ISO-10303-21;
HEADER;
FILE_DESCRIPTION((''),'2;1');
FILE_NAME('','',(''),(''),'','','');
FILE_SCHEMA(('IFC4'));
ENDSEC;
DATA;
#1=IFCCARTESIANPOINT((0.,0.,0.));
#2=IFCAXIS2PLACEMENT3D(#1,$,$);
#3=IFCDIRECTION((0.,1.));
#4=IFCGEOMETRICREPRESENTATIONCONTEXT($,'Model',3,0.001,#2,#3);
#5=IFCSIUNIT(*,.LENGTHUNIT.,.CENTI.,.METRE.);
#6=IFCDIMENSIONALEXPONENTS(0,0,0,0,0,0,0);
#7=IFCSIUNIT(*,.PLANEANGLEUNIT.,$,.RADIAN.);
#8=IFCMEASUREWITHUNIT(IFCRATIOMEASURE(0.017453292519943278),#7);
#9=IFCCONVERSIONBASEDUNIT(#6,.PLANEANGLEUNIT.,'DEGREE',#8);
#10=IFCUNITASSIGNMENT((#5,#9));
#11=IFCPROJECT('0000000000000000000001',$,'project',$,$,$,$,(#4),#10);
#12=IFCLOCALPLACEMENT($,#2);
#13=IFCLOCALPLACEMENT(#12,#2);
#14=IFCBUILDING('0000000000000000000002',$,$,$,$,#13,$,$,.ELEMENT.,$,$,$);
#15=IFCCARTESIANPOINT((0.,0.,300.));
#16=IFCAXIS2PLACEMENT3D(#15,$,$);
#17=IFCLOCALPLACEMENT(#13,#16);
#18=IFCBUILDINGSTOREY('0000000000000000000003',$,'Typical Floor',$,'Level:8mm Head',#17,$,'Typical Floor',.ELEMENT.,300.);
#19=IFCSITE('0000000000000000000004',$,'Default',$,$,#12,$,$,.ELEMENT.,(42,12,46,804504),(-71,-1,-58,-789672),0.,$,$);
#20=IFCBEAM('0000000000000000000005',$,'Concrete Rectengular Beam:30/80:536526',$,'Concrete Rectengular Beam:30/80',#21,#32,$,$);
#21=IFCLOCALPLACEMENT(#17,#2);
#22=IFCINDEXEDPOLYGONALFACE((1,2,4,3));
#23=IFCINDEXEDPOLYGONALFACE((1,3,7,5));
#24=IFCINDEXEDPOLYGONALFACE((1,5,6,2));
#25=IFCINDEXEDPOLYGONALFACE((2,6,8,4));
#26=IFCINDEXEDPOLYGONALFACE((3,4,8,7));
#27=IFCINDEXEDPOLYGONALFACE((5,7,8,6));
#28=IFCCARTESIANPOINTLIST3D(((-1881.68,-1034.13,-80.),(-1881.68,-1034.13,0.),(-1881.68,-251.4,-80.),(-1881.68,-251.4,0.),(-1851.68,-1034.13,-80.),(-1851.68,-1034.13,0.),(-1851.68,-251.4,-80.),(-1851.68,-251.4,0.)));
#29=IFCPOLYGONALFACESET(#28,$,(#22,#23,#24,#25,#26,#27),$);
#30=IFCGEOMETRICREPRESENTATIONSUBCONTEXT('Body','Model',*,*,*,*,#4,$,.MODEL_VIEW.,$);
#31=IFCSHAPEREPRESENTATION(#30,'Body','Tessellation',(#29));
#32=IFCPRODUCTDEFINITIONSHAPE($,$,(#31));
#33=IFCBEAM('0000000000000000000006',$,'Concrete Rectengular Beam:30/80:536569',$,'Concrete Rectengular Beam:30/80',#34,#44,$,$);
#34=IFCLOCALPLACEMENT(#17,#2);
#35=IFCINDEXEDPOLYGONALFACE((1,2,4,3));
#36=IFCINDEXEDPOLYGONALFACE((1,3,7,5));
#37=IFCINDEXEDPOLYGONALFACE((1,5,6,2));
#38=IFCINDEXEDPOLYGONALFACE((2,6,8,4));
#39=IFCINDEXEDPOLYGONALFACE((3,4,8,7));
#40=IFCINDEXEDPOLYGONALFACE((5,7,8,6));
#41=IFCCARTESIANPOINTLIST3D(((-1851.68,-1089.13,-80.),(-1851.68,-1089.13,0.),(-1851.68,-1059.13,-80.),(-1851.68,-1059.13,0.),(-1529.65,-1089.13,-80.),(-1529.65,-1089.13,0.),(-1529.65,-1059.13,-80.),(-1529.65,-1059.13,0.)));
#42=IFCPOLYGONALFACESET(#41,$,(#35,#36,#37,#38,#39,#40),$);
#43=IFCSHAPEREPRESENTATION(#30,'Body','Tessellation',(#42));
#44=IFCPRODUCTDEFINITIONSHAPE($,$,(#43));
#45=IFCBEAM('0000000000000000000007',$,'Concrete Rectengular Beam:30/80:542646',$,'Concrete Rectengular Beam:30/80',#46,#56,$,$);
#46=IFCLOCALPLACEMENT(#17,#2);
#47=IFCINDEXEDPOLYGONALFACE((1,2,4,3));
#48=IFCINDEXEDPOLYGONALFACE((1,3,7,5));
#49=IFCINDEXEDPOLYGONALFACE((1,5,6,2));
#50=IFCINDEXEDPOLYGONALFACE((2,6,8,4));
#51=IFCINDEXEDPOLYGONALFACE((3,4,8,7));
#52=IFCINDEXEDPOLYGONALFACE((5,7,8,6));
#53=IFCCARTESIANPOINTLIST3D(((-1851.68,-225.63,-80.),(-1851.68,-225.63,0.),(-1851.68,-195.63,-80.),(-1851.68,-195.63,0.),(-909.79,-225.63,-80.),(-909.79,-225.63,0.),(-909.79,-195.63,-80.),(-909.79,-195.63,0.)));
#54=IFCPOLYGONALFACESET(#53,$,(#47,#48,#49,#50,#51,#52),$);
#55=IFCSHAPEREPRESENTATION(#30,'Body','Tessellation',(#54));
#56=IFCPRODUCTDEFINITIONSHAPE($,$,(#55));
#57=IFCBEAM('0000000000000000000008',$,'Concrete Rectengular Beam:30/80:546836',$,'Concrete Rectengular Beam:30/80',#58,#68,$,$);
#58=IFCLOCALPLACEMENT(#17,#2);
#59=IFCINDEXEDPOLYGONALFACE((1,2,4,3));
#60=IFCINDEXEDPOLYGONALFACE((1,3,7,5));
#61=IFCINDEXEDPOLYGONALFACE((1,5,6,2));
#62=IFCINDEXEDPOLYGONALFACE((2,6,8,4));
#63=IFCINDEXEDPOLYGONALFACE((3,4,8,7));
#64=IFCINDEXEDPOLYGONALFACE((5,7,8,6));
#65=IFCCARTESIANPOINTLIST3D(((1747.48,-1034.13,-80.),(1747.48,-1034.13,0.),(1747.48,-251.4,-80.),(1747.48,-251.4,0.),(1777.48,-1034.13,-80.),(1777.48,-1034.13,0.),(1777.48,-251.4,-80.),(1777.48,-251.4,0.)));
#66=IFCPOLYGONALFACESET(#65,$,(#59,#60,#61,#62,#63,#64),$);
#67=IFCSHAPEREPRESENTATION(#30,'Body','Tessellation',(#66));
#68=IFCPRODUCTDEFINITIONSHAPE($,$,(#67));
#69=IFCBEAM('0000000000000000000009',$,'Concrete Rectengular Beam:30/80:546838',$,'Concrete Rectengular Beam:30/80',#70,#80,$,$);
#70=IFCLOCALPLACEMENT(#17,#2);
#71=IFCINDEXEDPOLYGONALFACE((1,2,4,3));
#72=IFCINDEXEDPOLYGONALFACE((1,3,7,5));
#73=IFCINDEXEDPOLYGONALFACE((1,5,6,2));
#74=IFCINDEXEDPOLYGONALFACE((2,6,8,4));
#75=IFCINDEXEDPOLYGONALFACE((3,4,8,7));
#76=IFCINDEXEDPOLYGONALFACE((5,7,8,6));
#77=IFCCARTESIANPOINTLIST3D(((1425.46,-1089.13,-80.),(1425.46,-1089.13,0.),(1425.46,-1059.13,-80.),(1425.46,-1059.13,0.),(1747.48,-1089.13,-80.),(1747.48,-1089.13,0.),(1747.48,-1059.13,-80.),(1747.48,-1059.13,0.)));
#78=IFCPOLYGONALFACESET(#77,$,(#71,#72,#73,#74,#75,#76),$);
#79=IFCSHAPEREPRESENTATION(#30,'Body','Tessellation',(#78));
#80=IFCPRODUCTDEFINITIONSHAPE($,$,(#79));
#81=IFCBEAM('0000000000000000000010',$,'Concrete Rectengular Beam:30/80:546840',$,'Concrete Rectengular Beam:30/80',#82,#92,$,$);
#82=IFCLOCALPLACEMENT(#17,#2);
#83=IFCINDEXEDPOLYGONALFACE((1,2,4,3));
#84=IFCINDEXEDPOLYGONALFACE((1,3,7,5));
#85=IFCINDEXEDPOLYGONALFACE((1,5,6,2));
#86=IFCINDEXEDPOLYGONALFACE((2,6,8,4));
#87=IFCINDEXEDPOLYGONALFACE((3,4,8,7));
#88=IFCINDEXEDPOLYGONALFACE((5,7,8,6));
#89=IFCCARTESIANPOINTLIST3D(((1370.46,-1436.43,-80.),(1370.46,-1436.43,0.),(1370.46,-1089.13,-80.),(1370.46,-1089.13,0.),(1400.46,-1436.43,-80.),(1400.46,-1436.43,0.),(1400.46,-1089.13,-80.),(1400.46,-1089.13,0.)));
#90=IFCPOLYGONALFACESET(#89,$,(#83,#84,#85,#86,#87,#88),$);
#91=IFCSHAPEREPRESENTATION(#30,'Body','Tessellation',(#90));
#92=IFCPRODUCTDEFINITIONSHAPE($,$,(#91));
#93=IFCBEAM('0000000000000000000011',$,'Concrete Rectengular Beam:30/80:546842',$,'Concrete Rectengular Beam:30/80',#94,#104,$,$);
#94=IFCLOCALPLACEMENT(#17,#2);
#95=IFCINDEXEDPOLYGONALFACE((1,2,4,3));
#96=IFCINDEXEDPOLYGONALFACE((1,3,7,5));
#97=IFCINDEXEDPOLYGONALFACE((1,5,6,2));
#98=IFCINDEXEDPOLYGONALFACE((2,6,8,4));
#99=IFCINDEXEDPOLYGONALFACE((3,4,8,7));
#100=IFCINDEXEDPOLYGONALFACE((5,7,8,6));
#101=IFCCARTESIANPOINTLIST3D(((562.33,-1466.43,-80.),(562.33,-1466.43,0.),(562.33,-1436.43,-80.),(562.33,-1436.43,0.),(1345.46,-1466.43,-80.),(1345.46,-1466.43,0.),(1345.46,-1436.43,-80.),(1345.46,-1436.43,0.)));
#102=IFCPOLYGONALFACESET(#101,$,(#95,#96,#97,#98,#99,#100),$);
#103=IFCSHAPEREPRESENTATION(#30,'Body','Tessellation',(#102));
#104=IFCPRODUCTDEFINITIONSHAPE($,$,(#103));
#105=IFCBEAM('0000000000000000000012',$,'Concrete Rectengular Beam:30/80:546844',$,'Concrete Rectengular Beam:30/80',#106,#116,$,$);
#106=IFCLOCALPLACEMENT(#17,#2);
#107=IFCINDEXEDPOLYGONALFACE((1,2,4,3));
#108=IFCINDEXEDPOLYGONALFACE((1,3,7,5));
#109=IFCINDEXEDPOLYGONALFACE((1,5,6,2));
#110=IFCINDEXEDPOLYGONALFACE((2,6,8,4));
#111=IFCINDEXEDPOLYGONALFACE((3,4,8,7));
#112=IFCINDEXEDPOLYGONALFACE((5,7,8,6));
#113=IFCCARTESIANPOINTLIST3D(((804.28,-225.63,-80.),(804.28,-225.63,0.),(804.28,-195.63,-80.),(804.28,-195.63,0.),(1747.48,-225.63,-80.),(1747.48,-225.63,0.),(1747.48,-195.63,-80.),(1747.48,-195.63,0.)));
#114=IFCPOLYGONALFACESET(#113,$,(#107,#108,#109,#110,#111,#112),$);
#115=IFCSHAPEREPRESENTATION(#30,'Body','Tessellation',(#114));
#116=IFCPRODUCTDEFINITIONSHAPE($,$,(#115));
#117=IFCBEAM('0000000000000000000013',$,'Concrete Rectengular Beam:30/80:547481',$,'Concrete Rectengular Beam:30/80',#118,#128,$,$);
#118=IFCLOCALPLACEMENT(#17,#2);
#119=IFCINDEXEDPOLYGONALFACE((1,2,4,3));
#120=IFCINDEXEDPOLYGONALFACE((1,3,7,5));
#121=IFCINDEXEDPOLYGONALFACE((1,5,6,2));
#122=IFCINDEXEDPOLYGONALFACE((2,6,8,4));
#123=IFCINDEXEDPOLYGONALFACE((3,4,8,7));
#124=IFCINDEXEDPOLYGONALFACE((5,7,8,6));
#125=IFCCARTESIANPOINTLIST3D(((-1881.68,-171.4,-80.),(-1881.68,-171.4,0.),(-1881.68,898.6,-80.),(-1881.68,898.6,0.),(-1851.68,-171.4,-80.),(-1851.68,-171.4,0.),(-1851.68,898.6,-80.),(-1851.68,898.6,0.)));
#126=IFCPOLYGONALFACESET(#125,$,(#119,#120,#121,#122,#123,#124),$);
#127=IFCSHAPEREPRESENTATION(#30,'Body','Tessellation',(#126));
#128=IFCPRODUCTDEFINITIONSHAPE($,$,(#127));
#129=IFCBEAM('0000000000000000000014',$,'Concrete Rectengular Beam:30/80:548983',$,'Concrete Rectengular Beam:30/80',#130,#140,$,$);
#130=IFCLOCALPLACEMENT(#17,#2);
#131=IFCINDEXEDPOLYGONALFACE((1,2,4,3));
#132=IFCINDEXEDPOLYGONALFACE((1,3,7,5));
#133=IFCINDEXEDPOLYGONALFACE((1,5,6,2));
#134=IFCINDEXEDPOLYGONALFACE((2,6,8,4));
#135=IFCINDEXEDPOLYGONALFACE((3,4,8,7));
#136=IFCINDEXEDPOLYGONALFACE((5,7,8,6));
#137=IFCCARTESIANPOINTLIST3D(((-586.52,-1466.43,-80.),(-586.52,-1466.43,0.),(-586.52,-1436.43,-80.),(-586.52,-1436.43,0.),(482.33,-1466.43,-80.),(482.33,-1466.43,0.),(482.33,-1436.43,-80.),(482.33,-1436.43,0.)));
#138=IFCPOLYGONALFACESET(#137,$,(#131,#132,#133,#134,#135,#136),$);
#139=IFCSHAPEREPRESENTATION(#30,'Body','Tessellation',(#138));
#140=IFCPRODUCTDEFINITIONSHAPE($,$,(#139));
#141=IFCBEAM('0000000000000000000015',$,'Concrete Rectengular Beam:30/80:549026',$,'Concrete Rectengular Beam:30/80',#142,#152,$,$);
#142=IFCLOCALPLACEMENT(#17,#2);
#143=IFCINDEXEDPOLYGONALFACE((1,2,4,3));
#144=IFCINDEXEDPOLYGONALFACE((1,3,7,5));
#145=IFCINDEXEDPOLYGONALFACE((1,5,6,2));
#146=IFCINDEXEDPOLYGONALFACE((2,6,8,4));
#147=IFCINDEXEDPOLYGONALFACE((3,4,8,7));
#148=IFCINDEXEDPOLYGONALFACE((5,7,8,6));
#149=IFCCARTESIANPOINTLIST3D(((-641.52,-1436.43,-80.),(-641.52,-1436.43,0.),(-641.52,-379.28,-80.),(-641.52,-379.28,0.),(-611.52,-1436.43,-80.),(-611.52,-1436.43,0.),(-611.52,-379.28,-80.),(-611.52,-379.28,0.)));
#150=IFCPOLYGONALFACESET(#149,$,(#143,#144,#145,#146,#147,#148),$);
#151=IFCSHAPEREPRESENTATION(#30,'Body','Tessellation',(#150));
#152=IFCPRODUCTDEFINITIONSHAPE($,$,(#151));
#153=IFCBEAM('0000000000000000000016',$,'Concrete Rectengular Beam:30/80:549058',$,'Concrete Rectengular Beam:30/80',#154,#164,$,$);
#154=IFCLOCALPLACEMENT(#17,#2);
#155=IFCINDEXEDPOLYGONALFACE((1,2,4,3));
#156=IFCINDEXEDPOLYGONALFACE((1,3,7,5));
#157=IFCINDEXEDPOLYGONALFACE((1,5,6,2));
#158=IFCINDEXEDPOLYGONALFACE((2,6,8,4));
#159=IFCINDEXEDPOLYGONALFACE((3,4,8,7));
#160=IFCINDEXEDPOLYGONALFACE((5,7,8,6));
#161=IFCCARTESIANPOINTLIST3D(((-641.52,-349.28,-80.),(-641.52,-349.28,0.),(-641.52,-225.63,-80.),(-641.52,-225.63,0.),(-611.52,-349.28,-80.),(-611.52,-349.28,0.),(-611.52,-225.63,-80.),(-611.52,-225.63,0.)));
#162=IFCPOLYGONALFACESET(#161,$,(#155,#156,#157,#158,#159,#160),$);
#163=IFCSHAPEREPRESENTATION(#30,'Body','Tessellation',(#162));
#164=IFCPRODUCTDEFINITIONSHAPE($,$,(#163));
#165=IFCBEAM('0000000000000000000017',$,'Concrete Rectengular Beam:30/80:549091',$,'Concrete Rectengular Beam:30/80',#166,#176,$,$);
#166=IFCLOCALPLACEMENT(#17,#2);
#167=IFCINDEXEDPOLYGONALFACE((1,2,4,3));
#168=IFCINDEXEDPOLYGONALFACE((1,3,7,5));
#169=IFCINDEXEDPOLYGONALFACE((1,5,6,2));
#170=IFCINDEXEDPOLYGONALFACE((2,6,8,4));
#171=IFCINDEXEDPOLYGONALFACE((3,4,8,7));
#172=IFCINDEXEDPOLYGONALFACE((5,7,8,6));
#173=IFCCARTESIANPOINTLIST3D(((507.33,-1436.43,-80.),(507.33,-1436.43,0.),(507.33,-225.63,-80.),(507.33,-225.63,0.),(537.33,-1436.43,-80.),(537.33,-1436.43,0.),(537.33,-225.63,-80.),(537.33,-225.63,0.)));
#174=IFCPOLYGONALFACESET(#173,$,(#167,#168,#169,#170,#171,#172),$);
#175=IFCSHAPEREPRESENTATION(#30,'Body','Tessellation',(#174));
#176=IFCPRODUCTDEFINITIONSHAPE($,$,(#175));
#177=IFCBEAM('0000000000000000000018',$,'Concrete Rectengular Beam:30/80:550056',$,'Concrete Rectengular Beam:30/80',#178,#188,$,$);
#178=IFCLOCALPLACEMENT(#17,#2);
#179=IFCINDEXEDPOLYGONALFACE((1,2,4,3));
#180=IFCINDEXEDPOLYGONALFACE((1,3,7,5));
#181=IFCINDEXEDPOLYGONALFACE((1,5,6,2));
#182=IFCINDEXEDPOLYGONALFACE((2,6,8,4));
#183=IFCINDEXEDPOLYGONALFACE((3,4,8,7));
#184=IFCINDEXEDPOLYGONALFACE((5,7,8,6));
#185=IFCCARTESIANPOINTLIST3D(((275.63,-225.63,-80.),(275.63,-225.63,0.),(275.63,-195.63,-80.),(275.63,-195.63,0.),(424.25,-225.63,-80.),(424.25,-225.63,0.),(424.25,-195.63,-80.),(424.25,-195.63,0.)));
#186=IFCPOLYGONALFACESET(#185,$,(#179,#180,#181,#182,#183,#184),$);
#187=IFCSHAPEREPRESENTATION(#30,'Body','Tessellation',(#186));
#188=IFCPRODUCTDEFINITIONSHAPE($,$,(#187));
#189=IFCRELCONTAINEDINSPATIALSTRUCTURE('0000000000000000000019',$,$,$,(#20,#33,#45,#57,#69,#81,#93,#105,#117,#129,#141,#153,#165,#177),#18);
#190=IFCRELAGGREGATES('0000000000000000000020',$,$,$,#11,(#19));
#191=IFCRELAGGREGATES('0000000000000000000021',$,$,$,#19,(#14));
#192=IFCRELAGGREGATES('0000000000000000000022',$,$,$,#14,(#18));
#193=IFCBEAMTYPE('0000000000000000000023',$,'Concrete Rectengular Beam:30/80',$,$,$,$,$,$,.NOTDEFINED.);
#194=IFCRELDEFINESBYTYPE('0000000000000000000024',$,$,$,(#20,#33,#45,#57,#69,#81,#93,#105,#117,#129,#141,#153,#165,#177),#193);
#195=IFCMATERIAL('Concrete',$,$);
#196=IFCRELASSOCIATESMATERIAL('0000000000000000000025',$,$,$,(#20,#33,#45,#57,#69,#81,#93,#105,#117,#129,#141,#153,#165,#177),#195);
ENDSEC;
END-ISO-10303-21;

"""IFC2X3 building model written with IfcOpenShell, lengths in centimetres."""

from ifc_helpers import new_model, entity, si_unit, converted_unit, direction, frame, frame_2d, origin, origin_2d_with_axis, place, context, subcontext, project, spatial, rectangle, extrude, material, type_object, element, save


model = new_model("IFC2X3")

# Units and contexts
model_context = context("Model", 3, precision=0.001, world=origin(), true_north=direction((0.0, 1.0)))
body_context = subcontext(model_context, "Body", "Model", "MODEL_VIEW")
ifc_project = project(units=[si_unit("LENGTHUNIT", "METRE", prefix="CENTI"), converted_unit("PLANEANGLEUNIT", "DEGREE", entity("IfcRatioMeasure", 0.017453292519943278), si_unit("PLANEANGLEUNIT", "RADIAN"), dimensions=[0, 0, 0, 0, 0, 0, 0])], contexts=[model_context])

# Site, building, storey
site_placement = place(None, origin())
site = spatial("IfcSite", under=ifc_project, at=site_placement, Name="Default", CompositionType="ELEMENT", RefLatitude=(42, 12, 46, 804504), RefLongitude=(-71, -1, -58, -789672), RefElevation=0.0)
building_placement = place(site_placement, origin())
building = spatial("IfcBuilding", under=site, at=building_placement, CompositionType="ELEMENT")
storey_placement = place(building_placement, frame((0.0, 0.0, 300.0)))
storey = spatial("IfcBuildingStorey", under=building, at=storey_placement, Name="Typical Floor", ObjectType="Level:8mm Head", LongName="Typical Floor", CompositionType="ELEMENT", Elevation=300.0)

# Beams
ifc_material = material(Name="Concrete")
beam_type = type_object("IfcBeamType", Name="Concrete Rectengular Beam:30/80", PredefinedType="NOTDEFINED")
beam_1_placement = place(storey_placement, frame((-1866.68, -1074.13, 0.0), z_axis=(0.0, 0.0, 1.0), x_axis=(0.0, 1.0, 0.0)))
element("IfcBeam", 1, at=beam_1_placement, inside=storey, type_object=beam_type, material=ifc_material, Name="Concrete Rectengular Beam:30/80:536526", ObjectType="Concrete Rectengular Beam:30/80", context=body_context, shape_type="SweptSolid", body=[
    extrude(rectangle(XDim=80.0, YDim=30.0, at=frame_2d((0.0, 0.0), x_axis=(1.0, 0.0))), frame((40.0, 0.0, -40.0), z_axis=(1.0, 0.0, 0.0), x_axis=(0.0, 0.0, -1.0)), (0.0, 0.0, 1.0), 782.73),
])
beam_2_placement = place(storey_placement, frame((-1866.68, -1074.13, 0.0)))
element("IfcBeam", 2, at=beam_2_placement, inside=storey, type_object=beam_type, material=ifc_material, Name="Concrete Rectengular Beam:30/80:536569", ObjectType="Concrete Rectengular Beam:30/80", context=body_context, shape_type="SweptSolid", body=[
    extrude(rectangle(XDim=80.0, YDim=30.0, at=frame_2d((0.0, 0.0), x_axis=(1.0, 0.0))), frame((15.0, 0.0, -40.0), z_axis=(1.0, 0.0, 0.0), x_axis=(0.0, 0.0, -1.0)), (0.0, 0.0, 1.0), 322.02),
])
beam_3_placement = place(storey_placement, frame((-894.79, -210.63, 0.0), z_axis=(0.0, 0.0, 1.0), x_axis=(-1.0, 0.0, 0.0)))
element("IfcBeam", 3, at=beam_3_placement, inside=storey, type_object=beam_type, material=ifc_material, Name="Concrete Rectengular Beam:30/80:542646", ObjectType="Concrete Rectengular Beam:30/80", context=body_context, shape_type="SweptSolid", body=[
    extrude(rectangle(XDim=80.0, YDim=30.0, at=frame_2d((0.0, 0.0), x_axis=(1.0, 0.0))), frame((15.0, 0.0, -40.0), z_axis=(1.0, 0.0, 0.0), x_axis=(0.0, 0.0, -1.0)), (0.0, 0.0, 1.0), 941.89),
])
beam_4_placement = place(storey_placement, frame((1762.48, -1074.13, 0.0), z_axis=(0.0, 0.0, 1.0), x_axis=(0.0, 1.0, 0.0)))
element("IfcBeam", 4, at=beam_4_placement, inside=storey, type_object=beam_type, material=ifc_material, Name="Concrete Rectengular Beam:30/80:546836", ObjectType="Concrete Rectengular Beam:30/80", context=body_context, shape_type="SweptSolid", body=[
    extrude(rectangle(XDim=80.0, YDim=30.0, at=frame_2d((0.0, 0.0), x_axis=(1.0, 0.0))), frame((40.0, 0.0, -40.0), z_axis=(1.0, 0.0, 0.0), x_axis=(0.0, 0.0, -1.0)), (0.0, 0.0, 1.0), 782.73),
])
beam_5_placement = place(storey_placement, frame((1762.48, -1074.13, 0.0), z_axis=(0.0, 0.0, 1.0), x_axis=(-1.0, 0.0, 0.0)))
element("IfcBeam", 5, at=beam_5_placement, inside=storey, type_object=beam_type, material=ifc_material, Name="Concrete Rectengular Beam:30/80:546838", ObjectType="Concrete Rectengular Beam:30/80", context=body_context, shape_type="SweptSolid", body=[
    extrude(rectangle(XDim=80.0, YDim=30.0, at=frame_2d((0.0, 0.0), x_axis=(1.0, 0.0))), frame((15.0, 0.0, -40.0), z_axis=(1.0, 0.0, 0.0), x_axis=(0.0, 0.0, -1.0)), (0.0, 0.0, 1.0), 322.02),
])
beam_6_placement = place(storey_placement, frame((1385.46, -1451.43, 0.0), z_axis=(0.0, 0.0, 1.0), x_axis=(0.0, 1.0, 0.0)))
element("IfcBeam", 6, at=beam_6_placement, inside=storey, type_object=beam_type, material=ifc_material, Name="Concrete Rectengular Beam:30/80:546840", ObjectType="Concrete Rectengular Beam:30/80", context=body_context, shape_type="SweptSolid", body=[
    extrude(rectangle(XDim=80.0, YDim=30.0, at=frame_2d((0.0, 0.0), x_axis=(1.0, 0.0))), frame((15.0, 0.0, -40.0), z_axis=(1.0, 0.0, 0.0), x_axis=(0.0, 0.0, -1.0)), (0.0, 0.0, 1.0), 347.31),
])
beam_7_placement = place(storey_placement, frame((1385.46, -1451.43, 0.0), z_axis=(0.0, 0.0, 1.0), x_axis=(-1.0, 0.0, 0.0)))
element("IfcBeam", 7, at=beam_7_placement, inside=storey, type_object=beam_type, material=ifc_material, Name="Concrete Rectengular Beam:30/80:546842", ObjectType="Concrete Rectengular Beam:30/80", context=body_context, shape_type="SweptSolid", body=[
    extrude(rectangle(XDim=80.0, YDim=30.0, at=frame_2d((0.0, 0.0), x_axis=(1.0, 0.0))), frame((40.0, 0.0, -40.0), z_axis=(1.0, 0.0, 0.0), x_axis=(0.0, 0.0, -1.0)), (0.0, 0.0, 1.0), 783.13),
])
beam_8_placement = place(storey_placement, frame((789.28, -210.63, 0.0)))
element("IfcBeam", 8, at=beam_8_placement, inside=storey, type_object=beam_type, material=ifc_material, Name="Concrete Rectengular Beam:30/80:546844", ObjectType="Concrete Rectengular Beam:30/80", context=body_context, shape_type="SweptSolid", body=[
    extrude(rectangle(XDim=80.0, YDim=30.0, at=frame_2d((0.0, 0.0), x_axis=(1.0, 0.0))), frame((15.0, 0.0, -40.0), z_axis=(1.0, 0.0, 0.0), x_axis=(0.0, 0.0, -1.0)), (0.0, 0.0, 1.0), 943.2),
])
beam_9_placement = place(storey_placement, frame((-1866.68, -211.4, 0.0), z_axis=(0.0, 0.0, 1.0), x_axis=(0.0, 1.0, 0.0)))
element("IfcBeam", 9, at=beam_9_placement, inside=storey, type_object=beam_type, material=ifc_material, Name="Concrete Rectengular Beam:30/80:547481", ObjectType="Concrete Rectengular Beam:30/80", context=body_context, shape_type="SweptSolid", body=[
    extrude(rectangle(XDim=80.0, YDim=30.0, at=frame_2d((0.0, 0.0), x_axis=(1.0, 0.0))), frame((40.0, 0.0, -40.0), z_axis=(1.0, 0.0, 0.0), x_axis=(0.0, 0.0, -1.0)), (0.0, 0.0, 1.0), 1070.0),
])
beam_10_placement = place(storey_placement, frame((522.33, -1451.43, 0.0), z_axis=(0.0, 0.0, 1.0), x_axis=(-1.0, 0.0, 0.0)))
element("IfcBeam", 10, at=beam_10_placement, inside=storey, type_object=beam_type, material=ifc_material, Name="Concrete Rectengular Beam:30/80:548983", ObjectType="Concrete Rectengular Beam:30/80", context=body_context, shape_type="SweptSolid", body=[
    extrude(rectangle(XDim=80.0, YDim=30.0, at=frame_2d((0.0, 0.0), x_axis=(1.0, 0.0))), frame((40.0, 0.0, -40.0), z_axis=(1.0, 0.0, 0.0), x_axis=(0.0, 0.0, -1.0)), (0.0, 0.0, 1.0), 1068.85),
])
beam_11_placement = place(storey_placement, frame((-626.52, -1451.43, 0.0), z_axis=(0.0, 0.0, 1.0), x_axis=(0.0, 1.0, 0.0)))
element("IfcBeam", 11, at=beam_11_placement, inside=storey, type_object=beam_type, material=ifc_material, Name="Concrete Rectengular Beam:30/80:549026", ObjectType="Concrete Rectengular Beam:30/80", context=body_context, shape_type="SweptSolid", body=[
    extrude(rectangle(XDim=80.0, YDim=30.0, at=frame_2d((0.0, 0.0), x_axis=(1.0, 0.0))), frame((15.0, 0.0, -40.0), z_axis=(1.0, 0.0, 0.0), x_axis=(0.0, 0.0, -1.0)), (0.0, 0.0, 1.0), 1057.15),
])
beam_12_placement = place(storey_placement, frame((-626.52, -364.28, 0.0), z_axis=(0.0, 0.0, 1.0), x_axis=(0.0, 1.0, 0.0)))
element("IfcBeam", 12, at=beam_12_placement, inside=storey, type_object=beam_type, material=ifc_material, Name="Concrete Rectengular Beam:30/80:549058", ObjectType="Concrete Rectengular Beam:30/80", context=body_context, shape_type="SweptSolid", body=[
    extrude(rectangle(XDim=80.0, YDim=30.0, at=origin_2d_with_axis()), frame((15.0, 0.0, -40.0), z_axis=(1.0, 0.0, 0.0), x_axis=(0.0, 0.0, -1.0)), (0.0, 0.0, 1.0), 123.65),
])
beam_13_placement = place(storey_placement, frame((522.33, -210.63, 0.0), z_axis=(0.0, 0.0, 1.0), x_axis=(0.0, -1.0, 0.0)))
element("IfcBeam", 13, at=beam_13_placement, inside=storey, type_object=beam_type, material=ifc_material, Name="Concrete Rectengular Beam:30/80:549091", ObjectType="Concrete Rectengular Beam:30/80", context=body_context, shape_type="SweptSolid", body=[
    extrude(rectangle(XDim=80.0, YDim=30.0, at=frame_2d((0.0, 0.0), x_axis=(1.0, 0.0))), frame((15.0, 0.0, -40.0), z_axis=(1.0, 0.0, 0.0), x_axis=(0.0, 0.0, -1.0)), (0.0, 0.0, 1.0), 1210.81),
])
beam_14_placement = place(storey_placement, frame((424.25, -210.63, 0.0), z_axis=(0.0, 0.0, 1.0), x_axis=(-1.0, 0.0, 0.0)))
element("IfcBeam", 14, at=beam_14_placement, inside=storey, type_object=beam_type, material=ifc_material, Name="Concrete Rectengular Beam:30/80:550056", ObjectType="Concrete Rectengular Beam:30/80", context=body_context, shape_type="SweptSolid", body=[
    extrude(rectangle(XDim=80.0, YDim=30.0, at=frame_2d((0.0, 0.0), x_axis=(1.0, 0.0))), frame((0.0, 0.0, -40.0), z_axis=(1.0, 0.0, 0.0), x_axis=(0.0, 0.0, -1.0)), (0.0, 0.0, 1.0), 148.62),
])

save(model, "model.ifc")
